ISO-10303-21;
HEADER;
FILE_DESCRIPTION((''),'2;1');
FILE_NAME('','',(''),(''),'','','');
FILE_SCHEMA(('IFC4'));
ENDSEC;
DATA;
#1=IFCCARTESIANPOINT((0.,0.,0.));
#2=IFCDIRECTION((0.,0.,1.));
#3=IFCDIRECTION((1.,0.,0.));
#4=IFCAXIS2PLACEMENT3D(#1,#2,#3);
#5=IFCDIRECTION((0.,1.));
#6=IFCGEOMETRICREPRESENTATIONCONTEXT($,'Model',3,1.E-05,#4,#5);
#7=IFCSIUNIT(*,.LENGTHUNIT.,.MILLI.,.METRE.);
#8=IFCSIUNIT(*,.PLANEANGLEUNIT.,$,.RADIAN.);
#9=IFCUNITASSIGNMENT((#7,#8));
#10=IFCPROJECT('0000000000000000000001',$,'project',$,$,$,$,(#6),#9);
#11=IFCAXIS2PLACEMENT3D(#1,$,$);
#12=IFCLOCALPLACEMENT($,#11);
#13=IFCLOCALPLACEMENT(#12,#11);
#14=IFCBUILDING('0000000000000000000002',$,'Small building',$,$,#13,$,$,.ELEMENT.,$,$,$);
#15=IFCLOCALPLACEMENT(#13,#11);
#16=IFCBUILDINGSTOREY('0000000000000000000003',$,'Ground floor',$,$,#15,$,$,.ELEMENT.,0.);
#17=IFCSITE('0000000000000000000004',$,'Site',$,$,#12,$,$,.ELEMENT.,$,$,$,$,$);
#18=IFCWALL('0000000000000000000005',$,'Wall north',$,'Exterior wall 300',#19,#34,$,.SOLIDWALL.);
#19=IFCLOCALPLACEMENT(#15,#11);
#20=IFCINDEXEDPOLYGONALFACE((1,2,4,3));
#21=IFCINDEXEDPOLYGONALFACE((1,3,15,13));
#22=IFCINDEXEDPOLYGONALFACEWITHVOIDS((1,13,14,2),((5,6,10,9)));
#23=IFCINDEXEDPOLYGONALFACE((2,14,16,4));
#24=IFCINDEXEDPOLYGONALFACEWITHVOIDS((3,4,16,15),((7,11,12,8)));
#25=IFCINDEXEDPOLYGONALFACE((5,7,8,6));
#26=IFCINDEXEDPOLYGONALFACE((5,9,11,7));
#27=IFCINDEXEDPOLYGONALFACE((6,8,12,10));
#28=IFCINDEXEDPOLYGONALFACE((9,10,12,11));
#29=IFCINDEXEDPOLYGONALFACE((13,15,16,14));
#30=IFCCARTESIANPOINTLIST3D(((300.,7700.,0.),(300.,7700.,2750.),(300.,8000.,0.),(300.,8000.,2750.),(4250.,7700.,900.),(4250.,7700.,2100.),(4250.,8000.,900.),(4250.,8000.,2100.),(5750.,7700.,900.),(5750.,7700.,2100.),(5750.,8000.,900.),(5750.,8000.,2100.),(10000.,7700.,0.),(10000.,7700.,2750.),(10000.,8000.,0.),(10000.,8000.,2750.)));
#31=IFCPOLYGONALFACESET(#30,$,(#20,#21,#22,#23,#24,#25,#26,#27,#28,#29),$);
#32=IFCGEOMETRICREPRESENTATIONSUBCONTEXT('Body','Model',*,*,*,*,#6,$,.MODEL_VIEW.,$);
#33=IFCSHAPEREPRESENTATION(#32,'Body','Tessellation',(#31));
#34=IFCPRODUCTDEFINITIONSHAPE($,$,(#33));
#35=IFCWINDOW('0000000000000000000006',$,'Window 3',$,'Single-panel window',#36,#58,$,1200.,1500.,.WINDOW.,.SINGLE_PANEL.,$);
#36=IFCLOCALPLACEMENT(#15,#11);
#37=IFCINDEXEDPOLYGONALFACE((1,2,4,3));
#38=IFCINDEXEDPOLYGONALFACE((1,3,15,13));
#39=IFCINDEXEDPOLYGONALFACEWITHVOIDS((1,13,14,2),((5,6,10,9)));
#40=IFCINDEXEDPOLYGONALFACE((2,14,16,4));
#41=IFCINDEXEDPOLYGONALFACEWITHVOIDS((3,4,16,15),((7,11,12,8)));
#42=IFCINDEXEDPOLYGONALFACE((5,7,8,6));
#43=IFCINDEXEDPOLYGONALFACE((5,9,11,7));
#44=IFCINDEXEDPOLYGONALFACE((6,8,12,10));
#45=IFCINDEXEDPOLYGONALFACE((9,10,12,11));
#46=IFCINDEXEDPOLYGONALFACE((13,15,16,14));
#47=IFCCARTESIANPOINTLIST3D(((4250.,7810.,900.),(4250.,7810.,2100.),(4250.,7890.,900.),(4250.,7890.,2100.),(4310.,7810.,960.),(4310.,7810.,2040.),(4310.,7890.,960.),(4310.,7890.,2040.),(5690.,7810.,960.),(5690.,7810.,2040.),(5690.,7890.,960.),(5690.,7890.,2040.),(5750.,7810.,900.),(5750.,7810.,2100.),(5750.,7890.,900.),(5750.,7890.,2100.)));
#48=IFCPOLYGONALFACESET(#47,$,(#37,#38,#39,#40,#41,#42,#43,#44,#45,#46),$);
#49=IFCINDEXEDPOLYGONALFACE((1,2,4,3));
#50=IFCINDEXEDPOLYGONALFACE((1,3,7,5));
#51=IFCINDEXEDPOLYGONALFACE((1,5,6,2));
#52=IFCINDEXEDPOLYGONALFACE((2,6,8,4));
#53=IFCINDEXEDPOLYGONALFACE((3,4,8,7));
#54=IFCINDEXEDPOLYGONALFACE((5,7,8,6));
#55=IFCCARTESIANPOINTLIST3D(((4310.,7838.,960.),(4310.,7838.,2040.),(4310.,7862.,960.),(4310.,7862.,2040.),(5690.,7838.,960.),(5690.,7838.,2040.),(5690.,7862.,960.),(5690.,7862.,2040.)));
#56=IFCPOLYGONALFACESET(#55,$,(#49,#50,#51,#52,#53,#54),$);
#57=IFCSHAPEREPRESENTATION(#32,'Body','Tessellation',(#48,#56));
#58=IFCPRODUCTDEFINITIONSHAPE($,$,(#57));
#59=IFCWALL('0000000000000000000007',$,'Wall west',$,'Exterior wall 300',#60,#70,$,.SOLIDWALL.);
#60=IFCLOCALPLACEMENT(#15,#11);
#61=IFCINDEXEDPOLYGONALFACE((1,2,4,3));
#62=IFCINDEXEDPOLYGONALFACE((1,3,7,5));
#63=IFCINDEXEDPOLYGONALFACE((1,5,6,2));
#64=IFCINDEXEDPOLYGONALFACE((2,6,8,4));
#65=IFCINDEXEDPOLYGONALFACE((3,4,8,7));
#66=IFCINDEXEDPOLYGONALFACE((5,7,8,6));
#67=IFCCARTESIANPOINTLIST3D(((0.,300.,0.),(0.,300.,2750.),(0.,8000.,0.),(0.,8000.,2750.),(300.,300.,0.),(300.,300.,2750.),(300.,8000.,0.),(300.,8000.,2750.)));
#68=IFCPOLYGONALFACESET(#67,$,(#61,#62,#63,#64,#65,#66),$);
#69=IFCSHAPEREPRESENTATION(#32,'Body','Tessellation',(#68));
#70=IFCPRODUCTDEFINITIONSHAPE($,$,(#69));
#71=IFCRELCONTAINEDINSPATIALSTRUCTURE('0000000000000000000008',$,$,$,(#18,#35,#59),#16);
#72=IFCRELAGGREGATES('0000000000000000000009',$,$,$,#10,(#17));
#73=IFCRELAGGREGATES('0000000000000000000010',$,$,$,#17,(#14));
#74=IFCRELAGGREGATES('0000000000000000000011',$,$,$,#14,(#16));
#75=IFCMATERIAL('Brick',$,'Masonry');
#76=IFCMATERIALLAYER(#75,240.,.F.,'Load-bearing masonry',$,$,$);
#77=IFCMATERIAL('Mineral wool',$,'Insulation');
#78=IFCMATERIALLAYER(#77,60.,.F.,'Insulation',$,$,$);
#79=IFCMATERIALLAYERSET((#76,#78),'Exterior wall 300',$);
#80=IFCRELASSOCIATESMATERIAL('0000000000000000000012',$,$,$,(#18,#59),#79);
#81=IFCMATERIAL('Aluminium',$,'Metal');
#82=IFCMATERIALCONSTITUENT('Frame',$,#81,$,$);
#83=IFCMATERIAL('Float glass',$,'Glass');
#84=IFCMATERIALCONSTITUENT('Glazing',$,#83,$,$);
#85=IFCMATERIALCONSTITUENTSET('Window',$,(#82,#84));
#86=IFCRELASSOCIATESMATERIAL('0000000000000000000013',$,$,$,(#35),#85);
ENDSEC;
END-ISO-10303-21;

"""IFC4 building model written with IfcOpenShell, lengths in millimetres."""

from ifc_helpers import new_model, si_unit, direction, frame, frame_2d, origin, origin_with_axes, origin_2d, place, context, subcontext, project, spatial, rectangle, hollow_rectangle, extrude, material, layer, layer_set, layer_usage, constituent, constituent_set, element, fill, save


model = new_model("IFC4")

# Units and contexts
model_context = context("Model", 3, precision=1e-05, world=origin_with_axes(), true_north=direction((0.0, 1.0)))
body_context = subcontext(model_context, "Body", "Model", "MODEL_VIEW")
ifc_project = project(units=[si_unit("LENGTHUNIT", "METRE", prefix="MILLI"), si_unit("PLANEANGLEUNIT", "RADIAN")], contexts=[model_context])

# Site, building, storey
site_placement = place(None, origin())
site = spatial("IfcSite", under=ifc_project, at=site_placement, Name="Site", CompositionType="ELEMENT")
building_placement = place(site_placement, origin())
building = spatial("IfcBuilding", under=site, at=building_placement, Name="Small building", CompositionType="ELEMENT")
storey_placement = place(building_placement, origin())
storey = spatial("IfcBuildingStorey", under=building, at=storey_placement, Name="Ground floor", CompositionType="ELEMENT", Elevation=0.0)

# Shared definitions
ifc_material_1 = material(Name="Brick", Category="Masonry")
ifc_layer_1 = layer(ifc_material_1, 240.0, ventilated=False, Name="Load-bearing masonry")
ifc_material_2 = material(Name="Mineral wool", Category="Insulation")
ifc_layer_2 = layer(ifc_material_2, 60.0, ventilated=False, Name="Insulation")
ifc_layer_set = layer_set([ifc_layer_1, ifc_layer_2], Name="Exterior wall 300")
ifc_material_3 = material(Name="Aluminium", Category="Metal")
ifc_constituent_1 = constituent(ifc_material_3, Name="Frame")
ifc_material_4 = material(Name="Float glass", Category="Glass")
ifc_constituent_2 = constituent(ifc_material_4, Name="Glazing")
ifc_constituent_set = constituent_set(constituents=[ifc_constituent_1, ifc_constituent_2], Name="Window")

# Wall, opening, window
ifc_layer_usage_1 = layer_usage(ifc_layer_set, "AXIS2", "POSITIVE", 0.0)
wall_1_placement = place(storey_placement, frame((10000.0, 8000.0, 0.0), x_axis=(-1.0, 0.0, 0.0)))
wall_1 = element("IfcWall", 1, at=wall_1_placement, inside=storey, material=ifc_layer_usage_1, Name="Wall north", ObjectType="Exterior wall 300", PredefinedType="SOLIDWALL", context=body_context, shape_type="SweptSolid", body=[
    extrude(rectangle(XDim=9700.0, YDim=300.0, at=frame_2d((4850.0, 150.0))), origin_with_axes(), (0.0, 0.0, 1.0), 2750.0),
])
opening_1_placement = place(wall_1_placement, frame((4250.0, 0.0, 900.0)))
opening_1 = element("IfcOpeningElement", 2, at=opening_1_placement, cuts=wall_1, PredefinedType="OPENING", context=body_context, shape_type="SweptSolid", body=[
    extrude(rectangle(XDim=1500.0, YDim=400.0, at=frame_2d((750.0, 150.0))), origin_with_axes(), (0.0, 0.0, 1.0), 1200.0),
])
window_1_placement = place(opening_1_placement, origin())
window_1 = element("IfcWindow", 3, at=window_1_placement, inside=storey, material=ifc_constituent_set, Name="Window 3", ObjectType="Single-panel window", OverallHeight=1200.0, OverallWidth=1500.0, PartitioningType="SINGLE_PANEL", PredefinedType="WINDOW", context=body_context, shape_type="SweptSolid", body=[
    extrude(hollow_rectangle(XDim=1500.0, YDim=1200.0, WallThickness=60.0, at=origin_2d()), frame((750.0, 110.0, 600.0), z_axis=(0.0, 1.0, 0.0), x_axis=(1.0, 0.0, 0.0)), (0.0, 0.0, 1.0), 80.0),
    extrude(rectangle(XDim=1380.0, YDim=1080.0, at=origin_2d()), frame((750.0, 138.0, 600.0), z_axis=(0.0, 1.0, 0.0), x_axis=(1.0, 0.0, 0.0)), (0.0, 0.0, 1.0), 24.0),
])
fill(opening_1, window_1)

# Wall
ifc_layer_usage_2 = layer_usage(ifc_layer_set, "AXIS2", "POSITIVE", 0.0)
wall_2_placement = place(storey_placement, frame((0.0, 8000.0, 0.0), x_axis=(0.0, -1.0, 0.0)))
element("IfcWall", 4, at=wall_2_placement, inside=storey, material=ifc_layer_usage_2, Name="Wall west", ObjectType="Exterior wall 300", PredefinedType="SOLIDWALL", context=body_context, shape_type="SweptSolid", body=[
    extrude(rectangle(XDim=7700.0, YDim=300.0, at=frame_2d((3850.0, 150.0))), origin_with_axes(), (0.0, 0.0, 1.0), 2750.0),
])

save(model, "model.ifc")
